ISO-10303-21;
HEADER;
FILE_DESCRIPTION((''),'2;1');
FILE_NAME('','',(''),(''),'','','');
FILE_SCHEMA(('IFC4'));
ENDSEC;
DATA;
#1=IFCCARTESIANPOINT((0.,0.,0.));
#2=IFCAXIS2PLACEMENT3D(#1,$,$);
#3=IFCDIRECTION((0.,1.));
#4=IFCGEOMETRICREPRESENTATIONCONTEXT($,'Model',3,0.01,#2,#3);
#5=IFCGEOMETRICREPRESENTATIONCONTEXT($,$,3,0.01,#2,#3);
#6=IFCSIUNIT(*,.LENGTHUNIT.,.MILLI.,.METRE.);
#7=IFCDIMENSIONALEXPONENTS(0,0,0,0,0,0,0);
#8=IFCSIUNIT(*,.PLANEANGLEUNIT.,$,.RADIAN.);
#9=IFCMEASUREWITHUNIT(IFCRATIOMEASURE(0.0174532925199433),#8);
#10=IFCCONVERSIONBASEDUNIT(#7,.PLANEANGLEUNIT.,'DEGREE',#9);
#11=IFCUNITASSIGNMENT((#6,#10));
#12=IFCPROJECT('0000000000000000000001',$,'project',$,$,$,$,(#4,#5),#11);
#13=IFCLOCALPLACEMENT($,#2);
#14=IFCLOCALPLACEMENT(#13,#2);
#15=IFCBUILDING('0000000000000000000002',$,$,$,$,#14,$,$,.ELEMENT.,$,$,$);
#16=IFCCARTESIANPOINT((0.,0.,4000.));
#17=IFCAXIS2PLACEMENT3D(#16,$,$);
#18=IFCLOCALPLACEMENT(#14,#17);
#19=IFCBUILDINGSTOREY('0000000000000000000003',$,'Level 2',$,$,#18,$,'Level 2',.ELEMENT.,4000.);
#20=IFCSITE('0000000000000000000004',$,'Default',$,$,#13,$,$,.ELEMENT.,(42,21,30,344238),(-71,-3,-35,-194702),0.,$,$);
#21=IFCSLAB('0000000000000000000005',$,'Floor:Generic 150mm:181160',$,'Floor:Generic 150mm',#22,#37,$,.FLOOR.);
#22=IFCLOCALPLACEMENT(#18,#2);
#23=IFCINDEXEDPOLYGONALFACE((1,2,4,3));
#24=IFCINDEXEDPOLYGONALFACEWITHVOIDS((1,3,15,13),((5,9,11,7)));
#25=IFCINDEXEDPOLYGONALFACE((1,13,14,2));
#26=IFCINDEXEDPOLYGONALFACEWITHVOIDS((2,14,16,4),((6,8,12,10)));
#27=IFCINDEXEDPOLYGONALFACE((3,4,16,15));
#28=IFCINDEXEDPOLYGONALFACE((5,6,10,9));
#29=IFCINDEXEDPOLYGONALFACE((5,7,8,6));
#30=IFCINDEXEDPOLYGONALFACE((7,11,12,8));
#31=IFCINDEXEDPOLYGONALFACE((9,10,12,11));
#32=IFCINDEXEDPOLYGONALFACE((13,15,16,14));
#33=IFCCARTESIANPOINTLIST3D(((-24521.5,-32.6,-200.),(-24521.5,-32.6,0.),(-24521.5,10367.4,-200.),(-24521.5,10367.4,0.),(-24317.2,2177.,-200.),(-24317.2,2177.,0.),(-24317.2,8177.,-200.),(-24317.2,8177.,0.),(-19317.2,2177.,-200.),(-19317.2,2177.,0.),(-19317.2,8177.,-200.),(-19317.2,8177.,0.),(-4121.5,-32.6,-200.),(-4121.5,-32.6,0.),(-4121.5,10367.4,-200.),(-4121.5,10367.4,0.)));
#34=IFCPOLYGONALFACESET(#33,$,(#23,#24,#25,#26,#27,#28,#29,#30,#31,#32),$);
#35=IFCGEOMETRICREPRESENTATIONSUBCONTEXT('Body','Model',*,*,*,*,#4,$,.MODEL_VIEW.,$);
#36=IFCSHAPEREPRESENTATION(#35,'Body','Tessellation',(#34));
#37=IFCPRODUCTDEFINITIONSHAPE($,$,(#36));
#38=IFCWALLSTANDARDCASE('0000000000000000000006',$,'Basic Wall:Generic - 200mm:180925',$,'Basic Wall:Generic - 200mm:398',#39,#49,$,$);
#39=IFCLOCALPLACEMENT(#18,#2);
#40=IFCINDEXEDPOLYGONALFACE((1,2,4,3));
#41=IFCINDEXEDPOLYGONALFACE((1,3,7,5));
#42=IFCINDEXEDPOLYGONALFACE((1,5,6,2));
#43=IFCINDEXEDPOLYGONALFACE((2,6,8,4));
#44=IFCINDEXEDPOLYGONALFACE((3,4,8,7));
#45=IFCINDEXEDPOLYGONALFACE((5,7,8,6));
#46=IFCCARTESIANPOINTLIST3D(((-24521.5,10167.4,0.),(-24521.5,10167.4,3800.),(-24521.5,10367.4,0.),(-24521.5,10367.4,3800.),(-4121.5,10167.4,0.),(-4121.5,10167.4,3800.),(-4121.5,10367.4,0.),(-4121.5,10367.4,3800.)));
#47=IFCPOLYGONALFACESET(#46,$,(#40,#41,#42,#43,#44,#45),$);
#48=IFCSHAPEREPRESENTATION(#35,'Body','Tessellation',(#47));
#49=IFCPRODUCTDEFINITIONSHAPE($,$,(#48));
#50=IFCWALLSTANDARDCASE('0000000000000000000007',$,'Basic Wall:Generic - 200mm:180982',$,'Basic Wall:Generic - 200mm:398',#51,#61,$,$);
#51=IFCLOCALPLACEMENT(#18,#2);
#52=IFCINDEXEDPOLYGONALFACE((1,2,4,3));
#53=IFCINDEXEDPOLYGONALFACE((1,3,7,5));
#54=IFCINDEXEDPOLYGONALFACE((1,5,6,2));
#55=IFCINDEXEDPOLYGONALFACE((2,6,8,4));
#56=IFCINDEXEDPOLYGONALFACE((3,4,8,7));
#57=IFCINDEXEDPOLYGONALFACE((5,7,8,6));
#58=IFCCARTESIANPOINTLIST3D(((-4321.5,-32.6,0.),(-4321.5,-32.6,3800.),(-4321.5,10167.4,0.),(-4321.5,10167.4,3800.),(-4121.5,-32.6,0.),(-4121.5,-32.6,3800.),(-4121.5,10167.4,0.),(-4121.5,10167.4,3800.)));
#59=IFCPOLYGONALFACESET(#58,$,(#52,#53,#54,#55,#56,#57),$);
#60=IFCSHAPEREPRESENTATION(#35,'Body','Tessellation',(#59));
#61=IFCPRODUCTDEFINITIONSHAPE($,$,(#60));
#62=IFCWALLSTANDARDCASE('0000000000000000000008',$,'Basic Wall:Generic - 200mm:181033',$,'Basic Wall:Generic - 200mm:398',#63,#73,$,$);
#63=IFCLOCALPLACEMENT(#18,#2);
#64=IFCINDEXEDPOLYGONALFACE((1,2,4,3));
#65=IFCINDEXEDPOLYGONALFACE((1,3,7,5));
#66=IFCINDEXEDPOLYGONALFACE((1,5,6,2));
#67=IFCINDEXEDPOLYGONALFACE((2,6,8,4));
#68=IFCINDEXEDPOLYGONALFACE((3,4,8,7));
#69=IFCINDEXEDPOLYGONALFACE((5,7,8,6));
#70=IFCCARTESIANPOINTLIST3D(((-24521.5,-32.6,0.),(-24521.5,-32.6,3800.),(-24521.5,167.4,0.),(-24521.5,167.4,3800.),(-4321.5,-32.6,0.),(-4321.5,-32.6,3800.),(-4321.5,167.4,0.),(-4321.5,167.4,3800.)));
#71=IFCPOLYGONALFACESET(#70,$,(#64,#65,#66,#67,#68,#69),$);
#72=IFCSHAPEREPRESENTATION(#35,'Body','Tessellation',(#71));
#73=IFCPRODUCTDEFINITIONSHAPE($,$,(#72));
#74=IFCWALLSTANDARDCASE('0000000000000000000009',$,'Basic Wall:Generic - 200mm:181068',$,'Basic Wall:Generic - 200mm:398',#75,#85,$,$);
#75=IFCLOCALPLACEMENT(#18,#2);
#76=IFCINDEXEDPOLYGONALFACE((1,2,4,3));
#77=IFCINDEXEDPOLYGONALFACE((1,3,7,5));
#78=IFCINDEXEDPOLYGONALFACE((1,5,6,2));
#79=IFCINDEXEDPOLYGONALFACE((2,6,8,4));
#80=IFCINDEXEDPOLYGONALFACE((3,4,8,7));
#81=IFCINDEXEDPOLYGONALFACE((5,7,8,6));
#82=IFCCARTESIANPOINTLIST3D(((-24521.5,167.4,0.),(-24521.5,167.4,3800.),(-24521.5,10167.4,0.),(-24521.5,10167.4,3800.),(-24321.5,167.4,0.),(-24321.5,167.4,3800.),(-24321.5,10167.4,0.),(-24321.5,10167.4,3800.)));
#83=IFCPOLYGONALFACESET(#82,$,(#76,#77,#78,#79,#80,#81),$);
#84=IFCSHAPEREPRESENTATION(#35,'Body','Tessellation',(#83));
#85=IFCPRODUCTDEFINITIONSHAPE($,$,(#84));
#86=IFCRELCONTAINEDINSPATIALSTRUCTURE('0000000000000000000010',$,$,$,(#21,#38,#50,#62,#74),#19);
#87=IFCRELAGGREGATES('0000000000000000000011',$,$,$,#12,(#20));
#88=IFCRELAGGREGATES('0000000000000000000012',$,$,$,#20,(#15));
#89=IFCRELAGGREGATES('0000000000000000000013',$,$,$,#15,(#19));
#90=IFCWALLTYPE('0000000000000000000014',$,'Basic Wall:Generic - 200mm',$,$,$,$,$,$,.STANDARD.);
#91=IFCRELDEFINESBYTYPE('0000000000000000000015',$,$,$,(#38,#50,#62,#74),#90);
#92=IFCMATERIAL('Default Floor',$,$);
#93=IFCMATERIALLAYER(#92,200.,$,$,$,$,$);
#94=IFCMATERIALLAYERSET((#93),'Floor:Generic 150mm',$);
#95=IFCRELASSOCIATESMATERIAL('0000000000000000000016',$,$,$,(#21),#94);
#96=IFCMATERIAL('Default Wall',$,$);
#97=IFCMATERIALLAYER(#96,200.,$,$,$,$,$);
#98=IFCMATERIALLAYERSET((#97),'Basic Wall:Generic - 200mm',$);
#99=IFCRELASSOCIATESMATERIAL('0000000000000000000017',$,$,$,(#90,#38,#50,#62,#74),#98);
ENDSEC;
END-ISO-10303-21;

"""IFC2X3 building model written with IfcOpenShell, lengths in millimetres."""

from ifc_helpers import new_model, entity, si_unit, converted_unit, direction, frame, frame_2d, origin, origin_2d_with_axis, place, context, subcontext, project, spatial, rectangle, extrude, material, layer, layer_set, layer_usage, type_object, element, save


model = new_model("IFC2X3")

# Units and contexts
model_context = context("Model", 3, precision=0.01, world=origin(), true_north=direction((0.0, 1.0)))
context_of_model = context(None, 3, precision=0.01, world=origin(), true_north=direction((0.0, 1.0)))
body_context = subcontext(model_context, "Body", "Model", "MODEL_VIEW")
ifc_project = project(units=[si_unit("LENGTHUNIT", "METRE", prefix="MILLI"), converted_unit("PLANEANGLEUNIT", "DEGREE", entity("IfcRatioMeasure", 0.0174532925199433), si_unit("PLANEANGLEUNIT", "RADIAN"), dimensions=[0, 0, 0, 0, 0, 0, 0])], contexts=[model_context, context_of_model])

# Site, building, storey
site_placement = place(None, origin())
site = spatial("IfcSite", under=ifc_project, at=site_placement, Name="Default", CompositionType="ELEMENT", RefLatitude=(42, 21, 30, 344238), RefLongitude=(-71, -3, -35, -194702), RefElevation=0.0)
building_placement = place(site_placement, origin())
building = spatial("IfcBuilding", under=site, at=building_placement, CompositionType="ELEMENT")
storey_placement = place(building_placement, frame((0.0, 0.0, 4000.0)))
storey = spatial("IfcBuildingStorey", under=building, at=storey_placement, Name="Level 2", LongName="Level 2", CompositionType="ELEMENT", Elevation=4000.0)

# Slab, opening
ifc_material_1 = material(Name="Default Floor")
ifc_layer_1 = layer(ifc_material_1, 200.0)
ifc_layer_set_1 = layer_set([ifc_layer_1], Name="Floor:Generic 150mm")
ifc_layer_usage_1 = layer_usage(ifc_layer_set_1, "AXIS3", "POSITIVE", 0.0)
slab_placement = place(storey_placement, frame((-24521.5, -32.6, -200.0)))
slab = element("IfcSlab", 1, at=slab_placement, inside=storey, material=ifc_layer_usage_1, Name="Floor:Generic 150mm:181160", ObjectType="Floor:Generic 150mm", PredefinedType="FLOOR", context=body_context, shape_type="SweptSolid", body=[
    extrude(rectangle(XDim=10400.0, YDim=20400.0, at=frame_2d((0.0, 0.0), x_axis=(0.0, -1.0))), frame((10200.0, 5200.0, 200.0), z_axis=(0.0, 0.0, -1.0), x_axis=(-1.0, 0.0, 0.0)), (0.0, 0.0, 1.0), 200.0),
])
opening_placement = place(slab_placement, frame((2704.3, 5209.6, 200.0)))
element("IfcOpeningElement", 2, at=opening_placement, cuts=slab, ObjectType="Opening", context=body_context, shape_type="SweptSolid", body=[
    extrude(rectangle(XDim=5000.0, YDim=6000.0, at=origin_2d_with_axis()), frame((0.0, 0.0, 0.0), z_axis=(0.0, 0.0, -1.0), x_axis=(1.0, 0.0, 0.0)), (0.0, 0.0, 1.0), 200.0),
])

# Walls
ifc_material_2 = material(Name="Default Wall")
ifc_layer_2 = layer(ifc_material_2, 200.0)
ifc_layer_set_2 = layer_set([ifc_layer_2], Name="Basic Wall:Generic - 200mm")
ifc_layer_usage_2 = layer_usage(ifc_layer_set_2, "AXIS2", "NEGATIVE", 100.0)
wall_type = type_object("IfcWallType", Name="Basic Wall:Generic - 200mm", PredefinedType="STANDARD", material=ifc_layer_set_2)
wall_1_placement = place(storey_placement, frame((-24521.5, 10267.4, 0.0)))
element("IfcWallStandardCase", 3, at=wall_1_placement, inside=storey, type_object=wall_type, material=ifc_layer_usage_2, Name="Basic Wall:Generic - 200mm:180925", ObjectType="Basic Wall:Generic - 200mm:398", context=body_context, shape_type="SweptSolid", body=[
    extrude(rectangle(XDim=20400.0, YDim=200.0, at=frame_2d((10200.0, 0.0), x_axis=(-1.0, 0.0))), origin(), (0.0, 0.0, 1.0), 3800.0),
])
ifc_layer_usage_3 = layer_usage(ifc_layer_set_2, "AXIS2", "NEGATIVE", 100.0)
wall_2_placement = place(storey_placement, frame((-4221.5, 10167.4, 0.0), z_axis=(0.0, 0.0, 1.0), x_axis=(0.0, -1.0, 0.0)))
element("IfcWallStandardCase", 4, at=wall_2_placement, inside=storey, type_object=wall_type, material=ifc_layer_usage_3, Name="Basic Wall:Generic - 200mm:180982", ObjectType="Basic Wall:Generic - 200mm:398", context=body_context, shape_type="SweptSolid", body=[
    extrude(rectangle(XDim=10200.0, YDim=200.0, at=frame_2d((5100.0, 0.0), x_axis=(-1.0, 0.0))), origin(), (0.0, 0.0, 1.0), 3800.0),
])
ifc_layer_usage_4 = layer_usage(ifc_layer_set_2, "AXIS2", "NEGATIVE", 100.0)
wall_3_placement = place(storey_placement, frame((-4321.5, 67.4, 0.0), z_axis=(0.0, 0.0, 1.0), x_axis=(-1.0, 0.0, 0.0)))
element("IfcWallStandardCase", 5, at=wall_3_placement, inside=storey, type_object=wall_type, material=ifc_layer_usage_4, Name="Basic Wall:Generic - 200mm:181033", ObjectType="Basic Wall:Generic - 200mm:398", context=body_context, shape_type="SweptSolid", body=[
    extrude(rectangle(XDim=20200.0, YDim=200.0, at=frame_2d((10100.0, 0.0), x_axis=(-1.0, 0.0))), origin(), (0.0, 0.0, 1.0), 3800.0),
])
ifc_layer_usage_5 = layer_usage(ifc_layer_set_2, "AXIS2", "NEGATIVE", 100.0)
wall_4_placement = place(storey_placement, frame((-24421.5, 167.4, 0.0), z_axis=(0.0, 0.0, 1.0), x_axis=(0.0, 1.0, 0.0)))
element("IfcWallStandardCase", 6, at=wall_4_placement, inside=storey, type_object=wall_type, material=ifc_layer_usage_5, Name="Basic Wall:Generic - 200mm:181068", ObjectType="Basic Wall:Generic - 200mm:398", context=body_context, shape_type="SweptSolid", body=[
    extrude(rectangle(XDim=10000.0, YDim=200.0, at=frame_2d((5000.0, 0.0), x_axis=(-1.0, 0.0))), origin(), (0.0, 0.0, 1.0), 3800.0),
])

save(model, "model.ifc")
